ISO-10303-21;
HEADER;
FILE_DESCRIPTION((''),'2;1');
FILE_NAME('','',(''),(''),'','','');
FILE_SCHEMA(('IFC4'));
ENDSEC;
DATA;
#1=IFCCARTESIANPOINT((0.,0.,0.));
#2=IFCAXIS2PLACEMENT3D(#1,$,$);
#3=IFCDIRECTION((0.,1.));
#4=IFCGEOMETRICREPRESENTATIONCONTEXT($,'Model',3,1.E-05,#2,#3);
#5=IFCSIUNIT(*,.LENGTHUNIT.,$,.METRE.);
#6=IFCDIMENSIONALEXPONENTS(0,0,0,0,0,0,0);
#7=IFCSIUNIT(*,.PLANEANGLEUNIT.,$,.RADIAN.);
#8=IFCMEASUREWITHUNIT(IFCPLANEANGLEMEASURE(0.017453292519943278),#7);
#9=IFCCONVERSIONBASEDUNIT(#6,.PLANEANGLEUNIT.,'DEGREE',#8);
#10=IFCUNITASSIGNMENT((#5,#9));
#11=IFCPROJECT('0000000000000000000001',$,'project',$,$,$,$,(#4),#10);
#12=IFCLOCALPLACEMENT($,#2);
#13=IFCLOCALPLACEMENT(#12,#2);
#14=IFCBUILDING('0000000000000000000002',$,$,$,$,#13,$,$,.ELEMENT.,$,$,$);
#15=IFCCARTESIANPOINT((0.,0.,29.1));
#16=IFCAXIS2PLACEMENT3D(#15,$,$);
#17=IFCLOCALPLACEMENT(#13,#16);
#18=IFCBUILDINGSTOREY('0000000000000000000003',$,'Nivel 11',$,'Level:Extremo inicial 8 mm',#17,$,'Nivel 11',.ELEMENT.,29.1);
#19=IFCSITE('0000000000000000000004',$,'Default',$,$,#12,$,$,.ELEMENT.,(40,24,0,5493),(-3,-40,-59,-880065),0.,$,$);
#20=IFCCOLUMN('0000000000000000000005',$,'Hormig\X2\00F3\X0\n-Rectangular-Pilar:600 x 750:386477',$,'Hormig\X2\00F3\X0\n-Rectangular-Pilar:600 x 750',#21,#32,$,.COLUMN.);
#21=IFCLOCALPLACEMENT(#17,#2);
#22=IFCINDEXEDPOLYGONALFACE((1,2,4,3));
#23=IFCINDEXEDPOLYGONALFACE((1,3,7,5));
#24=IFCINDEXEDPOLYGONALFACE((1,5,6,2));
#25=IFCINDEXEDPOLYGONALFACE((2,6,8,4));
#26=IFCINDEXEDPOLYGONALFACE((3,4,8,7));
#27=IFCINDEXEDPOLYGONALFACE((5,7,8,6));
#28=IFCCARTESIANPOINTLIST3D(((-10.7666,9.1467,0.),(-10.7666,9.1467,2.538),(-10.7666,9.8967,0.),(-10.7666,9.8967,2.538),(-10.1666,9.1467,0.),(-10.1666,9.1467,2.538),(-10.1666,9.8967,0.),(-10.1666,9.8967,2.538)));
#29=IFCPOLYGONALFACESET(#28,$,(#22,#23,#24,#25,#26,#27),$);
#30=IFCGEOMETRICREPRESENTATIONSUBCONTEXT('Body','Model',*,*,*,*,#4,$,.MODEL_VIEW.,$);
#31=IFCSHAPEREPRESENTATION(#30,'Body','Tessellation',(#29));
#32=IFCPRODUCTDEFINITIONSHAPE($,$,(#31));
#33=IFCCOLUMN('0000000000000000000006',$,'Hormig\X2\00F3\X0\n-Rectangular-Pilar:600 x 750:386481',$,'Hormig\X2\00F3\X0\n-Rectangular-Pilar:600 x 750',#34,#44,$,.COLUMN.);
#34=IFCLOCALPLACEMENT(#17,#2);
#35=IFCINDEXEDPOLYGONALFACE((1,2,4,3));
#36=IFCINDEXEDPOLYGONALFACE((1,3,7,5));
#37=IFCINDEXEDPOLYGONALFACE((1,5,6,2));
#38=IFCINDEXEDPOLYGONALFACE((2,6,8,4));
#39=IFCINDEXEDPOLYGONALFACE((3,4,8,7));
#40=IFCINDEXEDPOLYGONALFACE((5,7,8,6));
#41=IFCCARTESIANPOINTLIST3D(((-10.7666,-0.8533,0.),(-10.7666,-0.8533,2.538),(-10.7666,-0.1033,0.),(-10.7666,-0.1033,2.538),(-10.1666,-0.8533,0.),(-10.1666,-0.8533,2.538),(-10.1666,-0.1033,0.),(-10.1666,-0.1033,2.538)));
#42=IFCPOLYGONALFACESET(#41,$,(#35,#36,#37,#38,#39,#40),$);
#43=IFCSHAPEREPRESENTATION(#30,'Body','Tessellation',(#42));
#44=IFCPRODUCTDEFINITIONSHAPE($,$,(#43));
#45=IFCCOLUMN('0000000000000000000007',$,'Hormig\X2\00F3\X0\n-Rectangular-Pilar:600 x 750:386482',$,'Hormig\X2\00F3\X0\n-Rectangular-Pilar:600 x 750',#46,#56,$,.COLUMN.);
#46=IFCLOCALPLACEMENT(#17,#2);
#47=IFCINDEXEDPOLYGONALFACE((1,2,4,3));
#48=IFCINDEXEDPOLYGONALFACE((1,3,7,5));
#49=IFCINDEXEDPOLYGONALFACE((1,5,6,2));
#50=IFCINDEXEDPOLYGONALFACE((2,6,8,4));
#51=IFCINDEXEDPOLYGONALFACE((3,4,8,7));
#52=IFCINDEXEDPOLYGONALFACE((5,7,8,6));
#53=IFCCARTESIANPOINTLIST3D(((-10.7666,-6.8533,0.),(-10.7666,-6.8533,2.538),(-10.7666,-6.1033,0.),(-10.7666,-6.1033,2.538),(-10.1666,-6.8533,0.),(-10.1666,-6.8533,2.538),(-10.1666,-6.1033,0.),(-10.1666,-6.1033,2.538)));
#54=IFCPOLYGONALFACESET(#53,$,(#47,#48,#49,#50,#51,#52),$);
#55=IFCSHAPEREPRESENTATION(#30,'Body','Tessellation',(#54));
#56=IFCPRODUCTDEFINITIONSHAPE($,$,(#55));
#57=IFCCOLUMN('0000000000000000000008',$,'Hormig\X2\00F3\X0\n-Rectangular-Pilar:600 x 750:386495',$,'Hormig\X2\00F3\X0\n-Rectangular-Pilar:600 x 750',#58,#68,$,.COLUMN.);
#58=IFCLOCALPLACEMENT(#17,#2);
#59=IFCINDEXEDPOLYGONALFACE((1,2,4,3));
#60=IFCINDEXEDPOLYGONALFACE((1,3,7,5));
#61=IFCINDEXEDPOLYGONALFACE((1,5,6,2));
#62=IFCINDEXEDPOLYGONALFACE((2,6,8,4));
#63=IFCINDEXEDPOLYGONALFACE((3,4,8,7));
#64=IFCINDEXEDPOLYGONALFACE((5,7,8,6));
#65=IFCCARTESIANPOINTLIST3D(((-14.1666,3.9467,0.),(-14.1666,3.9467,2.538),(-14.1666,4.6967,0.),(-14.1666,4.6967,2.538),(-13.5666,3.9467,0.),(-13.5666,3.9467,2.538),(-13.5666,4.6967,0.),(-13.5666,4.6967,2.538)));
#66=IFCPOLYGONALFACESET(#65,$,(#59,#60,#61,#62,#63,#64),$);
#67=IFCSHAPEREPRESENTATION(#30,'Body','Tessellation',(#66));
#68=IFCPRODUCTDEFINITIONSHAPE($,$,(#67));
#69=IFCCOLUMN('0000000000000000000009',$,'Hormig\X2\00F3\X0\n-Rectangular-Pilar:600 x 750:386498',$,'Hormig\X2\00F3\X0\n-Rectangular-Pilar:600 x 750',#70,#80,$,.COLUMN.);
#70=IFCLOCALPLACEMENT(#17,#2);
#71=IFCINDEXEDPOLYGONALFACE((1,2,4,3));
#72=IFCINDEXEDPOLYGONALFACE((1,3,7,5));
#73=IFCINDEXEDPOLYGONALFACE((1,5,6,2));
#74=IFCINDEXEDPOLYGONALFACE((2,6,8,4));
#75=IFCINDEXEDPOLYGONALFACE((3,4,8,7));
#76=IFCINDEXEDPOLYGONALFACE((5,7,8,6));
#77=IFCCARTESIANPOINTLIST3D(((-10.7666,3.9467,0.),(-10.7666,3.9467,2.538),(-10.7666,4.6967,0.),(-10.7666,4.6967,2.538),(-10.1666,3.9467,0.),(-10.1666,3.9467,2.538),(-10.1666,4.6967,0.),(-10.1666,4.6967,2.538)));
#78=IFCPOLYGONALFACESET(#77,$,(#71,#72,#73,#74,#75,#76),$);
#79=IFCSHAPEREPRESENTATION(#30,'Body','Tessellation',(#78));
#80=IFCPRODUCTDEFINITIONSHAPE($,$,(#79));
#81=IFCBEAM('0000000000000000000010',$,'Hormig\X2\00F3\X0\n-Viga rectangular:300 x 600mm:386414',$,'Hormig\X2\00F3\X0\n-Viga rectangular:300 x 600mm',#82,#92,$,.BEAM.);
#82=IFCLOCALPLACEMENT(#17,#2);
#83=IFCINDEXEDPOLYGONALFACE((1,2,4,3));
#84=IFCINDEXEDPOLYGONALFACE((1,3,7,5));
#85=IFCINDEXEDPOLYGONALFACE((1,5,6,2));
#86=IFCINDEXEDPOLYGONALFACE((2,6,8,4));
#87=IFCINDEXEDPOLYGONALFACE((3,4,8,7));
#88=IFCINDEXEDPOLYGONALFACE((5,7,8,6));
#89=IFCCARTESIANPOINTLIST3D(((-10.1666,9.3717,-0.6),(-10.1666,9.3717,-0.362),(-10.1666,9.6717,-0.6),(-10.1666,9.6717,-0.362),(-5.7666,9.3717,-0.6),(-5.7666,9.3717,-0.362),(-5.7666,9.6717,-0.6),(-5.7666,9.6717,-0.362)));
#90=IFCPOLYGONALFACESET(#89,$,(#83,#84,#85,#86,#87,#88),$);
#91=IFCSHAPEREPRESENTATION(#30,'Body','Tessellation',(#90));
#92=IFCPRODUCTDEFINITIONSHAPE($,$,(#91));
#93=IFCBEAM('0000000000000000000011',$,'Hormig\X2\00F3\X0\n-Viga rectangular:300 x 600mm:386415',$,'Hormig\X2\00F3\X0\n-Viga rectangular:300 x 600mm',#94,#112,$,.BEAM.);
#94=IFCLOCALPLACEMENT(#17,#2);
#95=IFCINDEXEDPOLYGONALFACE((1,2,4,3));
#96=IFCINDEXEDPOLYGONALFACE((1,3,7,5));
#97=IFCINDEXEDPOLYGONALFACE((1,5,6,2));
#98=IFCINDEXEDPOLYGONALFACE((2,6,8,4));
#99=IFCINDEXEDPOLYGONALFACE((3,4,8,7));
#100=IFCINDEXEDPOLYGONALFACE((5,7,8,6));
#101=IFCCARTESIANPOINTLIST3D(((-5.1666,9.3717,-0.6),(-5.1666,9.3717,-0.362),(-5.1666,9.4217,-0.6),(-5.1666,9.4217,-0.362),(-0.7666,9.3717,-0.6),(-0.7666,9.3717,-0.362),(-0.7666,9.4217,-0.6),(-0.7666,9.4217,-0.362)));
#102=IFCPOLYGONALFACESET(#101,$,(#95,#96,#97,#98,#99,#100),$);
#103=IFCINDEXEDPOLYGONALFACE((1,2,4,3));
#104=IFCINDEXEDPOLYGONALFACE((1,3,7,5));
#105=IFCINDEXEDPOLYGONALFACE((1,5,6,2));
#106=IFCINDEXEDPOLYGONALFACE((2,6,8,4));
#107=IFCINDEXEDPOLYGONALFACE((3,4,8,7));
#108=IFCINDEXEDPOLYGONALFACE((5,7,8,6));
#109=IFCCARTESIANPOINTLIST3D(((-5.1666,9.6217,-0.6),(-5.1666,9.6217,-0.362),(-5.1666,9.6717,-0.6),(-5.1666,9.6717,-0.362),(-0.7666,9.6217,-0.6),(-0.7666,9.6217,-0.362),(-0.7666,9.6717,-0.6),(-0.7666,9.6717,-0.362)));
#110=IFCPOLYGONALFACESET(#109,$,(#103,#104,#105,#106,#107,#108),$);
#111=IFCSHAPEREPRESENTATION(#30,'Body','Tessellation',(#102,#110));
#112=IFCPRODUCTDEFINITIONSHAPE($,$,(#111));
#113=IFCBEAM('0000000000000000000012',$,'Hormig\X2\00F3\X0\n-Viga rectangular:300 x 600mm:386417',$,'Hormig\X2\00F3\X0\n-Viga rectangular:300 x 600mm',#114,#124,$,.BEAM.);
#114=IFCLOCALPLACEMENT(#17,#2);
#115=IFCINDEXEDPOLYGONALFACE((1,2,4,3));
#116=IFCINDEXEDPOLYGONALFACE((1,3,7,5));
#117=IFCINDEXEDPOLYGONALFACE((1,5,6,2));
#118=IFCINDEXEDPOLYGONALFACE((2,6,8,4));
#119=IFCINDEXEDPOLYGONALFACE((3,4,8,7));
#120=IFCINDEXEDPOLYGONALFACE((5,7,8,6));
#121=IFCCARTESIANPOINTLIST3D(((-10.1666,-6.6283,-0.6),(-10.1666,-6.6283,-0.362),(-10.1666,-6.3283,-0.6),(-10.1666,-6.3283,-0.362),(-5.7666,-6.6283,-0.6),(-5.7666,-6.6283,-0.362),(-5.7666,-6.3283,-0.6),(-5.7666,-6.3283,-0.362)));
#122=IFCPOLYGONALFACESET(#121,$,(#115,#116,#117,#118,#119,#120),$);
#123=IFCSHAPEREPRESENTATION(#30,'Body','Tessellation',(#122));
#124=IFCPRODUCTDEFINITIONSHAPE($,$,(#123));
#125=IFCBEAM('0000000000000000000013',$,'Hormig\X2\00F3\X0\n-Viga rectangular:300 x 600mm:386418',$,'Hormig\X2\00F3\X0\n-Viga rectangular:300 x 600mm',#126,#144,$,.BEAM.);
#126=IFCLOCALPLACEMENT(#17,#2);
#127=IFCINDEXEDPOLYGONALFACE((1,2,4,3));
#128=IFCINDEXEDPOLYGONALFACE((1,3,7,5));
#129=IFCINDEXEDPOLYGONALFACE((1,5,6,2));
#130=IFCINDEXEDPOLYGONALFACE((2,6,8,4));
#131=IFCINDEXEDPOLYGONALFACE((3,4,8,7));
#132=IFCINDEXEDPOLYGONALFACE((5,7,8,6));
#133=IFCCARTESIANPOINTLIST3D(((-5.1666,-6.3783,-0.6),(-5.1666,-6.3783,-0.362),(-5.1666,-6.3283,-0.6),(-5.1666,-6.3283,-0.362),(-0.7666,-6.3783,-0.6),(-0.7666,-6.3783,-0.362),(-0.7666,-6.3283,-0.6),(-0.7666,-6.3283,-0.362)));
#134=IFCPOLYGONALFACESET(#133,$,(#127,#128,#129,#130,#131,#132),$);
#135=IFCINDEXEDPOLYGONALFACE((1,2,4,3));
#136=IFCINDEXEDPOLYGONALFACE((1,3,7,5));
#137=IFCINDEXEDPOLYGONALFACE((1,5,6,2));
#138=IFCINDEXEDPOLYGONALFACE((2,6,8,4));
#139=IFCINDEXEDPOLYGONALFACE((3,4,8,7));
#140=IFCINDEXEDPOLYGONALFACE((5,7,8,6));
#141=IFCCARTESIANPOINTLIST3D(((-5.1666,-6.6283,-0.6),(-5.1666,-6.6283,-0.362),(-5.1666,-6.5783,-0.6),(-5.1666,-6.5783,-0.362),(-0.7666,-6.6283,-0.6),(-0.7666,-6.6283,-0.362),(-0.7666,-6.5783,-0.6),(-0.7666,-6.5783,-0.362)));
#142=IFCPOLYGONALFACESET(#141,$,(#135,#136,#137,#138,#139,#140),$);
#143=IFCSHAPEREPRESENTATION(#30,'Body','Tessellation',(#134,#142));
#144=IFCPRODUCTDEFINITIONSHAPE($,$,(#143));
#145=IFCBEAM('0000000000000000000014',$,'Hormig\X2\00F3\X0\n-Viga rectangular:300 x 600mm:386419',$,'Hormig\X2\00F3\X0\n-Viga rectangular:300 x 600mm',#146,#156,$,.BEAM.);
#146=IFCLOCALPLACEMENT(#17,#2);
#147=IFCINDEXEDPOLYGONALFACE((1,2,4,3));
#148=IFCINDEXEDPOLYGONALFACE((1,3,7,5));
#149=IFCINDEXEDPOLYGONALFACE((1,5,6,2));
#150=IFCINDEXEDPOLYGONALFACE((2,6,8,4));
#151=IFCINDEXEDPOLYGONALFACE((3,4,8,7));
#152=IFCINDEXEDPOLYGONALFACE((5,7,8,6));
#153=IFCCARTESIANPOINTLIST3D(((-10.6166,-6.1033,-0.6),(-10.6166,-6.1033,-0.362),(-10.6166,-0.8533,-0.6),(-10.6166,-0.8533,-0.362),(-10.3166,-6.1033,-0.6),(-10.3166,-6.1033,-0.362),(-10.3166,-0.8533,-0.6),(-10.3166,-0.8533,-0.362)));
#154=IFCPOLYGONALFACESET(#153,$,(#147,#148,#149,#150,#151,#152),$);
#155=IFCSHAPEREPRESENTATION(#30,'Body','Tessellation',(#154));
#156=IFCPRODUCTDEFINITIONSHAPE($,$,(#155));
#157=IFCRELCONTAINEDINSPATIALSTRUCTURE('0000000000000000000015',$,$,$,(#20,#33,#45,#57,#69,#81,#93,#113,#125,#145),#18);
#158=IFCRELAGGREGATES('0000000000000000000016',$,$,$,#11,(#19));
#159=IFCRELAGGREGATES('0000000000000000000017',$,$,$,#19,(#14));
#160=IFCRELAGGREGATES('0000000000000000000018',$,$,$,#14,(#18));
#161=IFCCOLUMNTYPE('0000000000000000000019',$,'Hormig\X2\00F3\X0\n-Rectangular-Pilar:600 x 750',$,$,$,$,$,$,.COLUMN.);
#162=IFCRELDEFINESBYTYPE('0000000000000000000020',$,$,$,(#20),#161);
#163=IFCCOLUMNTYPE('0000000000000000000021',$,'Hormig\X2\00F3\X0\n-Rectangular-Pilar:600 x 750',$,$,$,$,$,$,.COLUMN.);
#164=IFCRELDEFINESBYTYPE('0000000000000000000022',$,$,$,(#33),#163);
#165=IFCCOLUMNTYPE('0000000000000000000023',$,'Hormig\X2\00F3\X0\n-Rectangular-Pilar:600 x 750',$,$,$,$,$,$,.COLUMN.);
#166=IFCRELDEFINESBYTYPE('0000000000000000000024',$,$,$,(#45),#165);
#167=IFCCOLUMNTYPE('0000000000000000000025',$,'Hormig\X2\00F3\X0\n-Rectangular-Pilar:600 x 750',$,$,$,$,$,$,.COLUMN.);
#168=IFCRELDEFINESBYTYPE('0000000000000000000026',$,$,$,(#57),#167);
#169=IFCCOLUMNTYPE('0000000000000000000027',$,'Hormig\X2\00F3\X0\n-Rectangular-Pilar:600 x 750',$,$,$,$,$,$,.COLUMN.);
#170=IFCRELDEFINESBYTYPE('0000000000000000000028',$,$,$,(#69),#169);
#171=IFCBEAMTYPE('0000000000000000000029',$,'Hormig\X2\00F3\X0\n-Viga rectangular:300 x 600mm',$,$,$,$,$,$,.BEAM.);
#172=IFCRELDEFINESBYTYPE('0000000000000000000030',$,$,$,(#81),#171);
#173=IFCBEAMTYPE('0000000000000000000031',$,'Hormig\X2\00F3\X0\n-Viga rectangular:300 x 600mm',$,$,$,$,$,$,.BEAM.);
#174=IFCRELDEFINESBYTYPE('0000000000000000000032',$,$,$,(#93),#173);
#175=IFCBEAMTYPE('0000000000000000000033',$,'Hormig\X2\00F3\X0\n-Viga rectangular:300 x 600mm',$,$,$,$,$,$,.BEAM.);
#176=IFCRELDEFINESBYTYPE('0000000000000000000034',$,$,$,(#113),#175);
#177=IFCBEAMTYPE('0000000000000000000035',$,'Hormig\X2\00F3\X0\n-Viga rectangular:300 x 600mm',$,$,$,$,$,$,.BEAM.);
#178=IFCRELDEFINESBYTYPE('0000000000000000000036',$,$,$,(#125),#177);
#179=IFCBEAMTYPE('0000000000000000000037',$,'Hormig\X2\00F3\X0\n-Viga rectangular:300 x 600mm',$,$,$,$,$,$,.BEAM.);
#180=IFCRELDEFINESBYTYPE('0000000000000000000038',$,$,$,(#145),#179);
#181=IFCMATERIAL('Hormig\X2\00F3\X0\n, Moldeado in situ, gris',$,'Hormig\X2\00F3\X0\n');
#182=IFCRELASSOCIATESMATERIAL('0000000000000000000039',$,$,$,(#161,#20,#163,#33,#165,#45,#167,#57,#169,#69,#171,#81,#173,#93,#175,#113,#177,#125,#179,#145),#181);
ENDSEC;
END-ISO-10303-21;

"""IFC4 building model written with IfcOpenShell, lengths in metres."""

from ifc_helpers import new_model, entity, si_unit, converted_unit, direction, frame, origin, place, context, subcontext, project, spatial, indexed_curve, outline, extrude, source, transform, mapped, material, type_object, type_shapes, element, save


model = new_model("IFC4")

# Units and contexts
model_context = context("Model", 3, precision=1e-05, world=origin(), true_north=direction((0.0, 1.0)))
body_context = subcontext(model_context, "Body", "Model", "MODEL_VIEW")
ifc_project = project(units=[si_unit("LENGTHUNIT", "METRE"), converted_unit("PLANEANGLEUNIT", "DEGREE", entity("IfcPlaneAngleMeasure", 0.017453292519943278), si_unit("PLANEANGLEUNIT", "RADIAN"), dimensions=[0, 0, 0, 0, 0, 0, 0])], contexts=[model_context])

# Site, building, storey
site_placement = place(None, origin())
site = spatial("IfcSite", under=ifc_project, at=site_placement, Name="Default", CompositionType="ELEMENT", RefLatitude=(40, 24, 0, 5493), RefLongitude=(-3, -40, -59, -880065), RefElevation=0.0)
building_placement = place(site_placement, origin())
building = spatial("IfcBuilding", under=site, at=building_placement, CompositionType="ELEMENT")
storey_placement = place(building_placement, frame((0.0, 0.0, 29.1)))
storey = spatial("IfcBuildingStorey", under=building, at=storey_placement, Name="Nivel 11", ObjectType="Level:Extremo inicial 8 mm", LongName="Nivel 11", CompositionType="ELEMENT", Elevation=29.1)

# Columns
ifc_material_1 = material(Name="Hormigón, Moldeado in situ, gris", Category="Hormigón")
column_type_1 = type_object("IfcColumnType", Name="Hormigón-Rectangular-Pilar:600 x 750", PredefinedType="COLUMN", material=ifc_material_1)
shared_shape_1 = source(origin(), body_context, "Body", "SweptSolid", [
    extrude(outline(indexed_curve([(-0.3, -0.375), (0.3, -0.375), (0.3, 0.375), (-0.3, 0.375), (-0.3, -0.375)], self_intersect=False)), frame((-10.4666, 9.5217, 29.1), z_axis=(0.0, 0.0, 1.0), x_axis=(-1.0, 0.0, 0.0)), (0.0, 0.0, 1.0), 2.538),
])
type_shapes(column_type_1, [shared_shape_1])
column_1_placement = place(storey_placement, frame((0.0, 0.0, -29.1)))
element("IfcColumn", 1, at=column_1_placement, inside=storey, type_object=column_type_1, material=ifc_material_1, Name="Hormigón-Rectangular-Pilar:600 x 750:386477", ObjectType="Hormigón-Rectangular-Pilar:600 x 750", PredefinedType="COLUMN", context=body_context, shape_type="MappedRepresentation", body=[
    mapped(shared_shape_1, transform((0.0, 0.0, 0.0), scale=1.0)),
])
column_type_2 = type_object("IfcColumnType", Name="Hormigón-Rectangular-Pilar:600 x 750", PredefinedType="COLUMN", material=ifc_material_1)
shared_shape_2 = source(origin(), body_context, "Body", "SweptSolid", [
    extrude(outline(indexed_curve([(-0.3, -0.375), (0.3, -0.375), (0.3, 0.375), (-0.3, 0.375), (-0.3, -0.375)], self_intersect=False)), frame((-10.4666, -0.4783, 29.1), z_axis=(0.0, 0.0, 1.0), x_axis=(-1.0, 0.0, 0.0)), (0.0, 0.0, 1.0), 2.538),
])
type_shapes(column_type_2, [shared_shape_2])
column_2_placement = place(storey_placement, frame((0.0, 0.0, -29.1)))
element("IfcColumn", 2, at=column_2_placement, inside=storey, type_object=column_type_2, material=ifc_material_1, Name="Hormigón-Rectangular-Pilar:600 x 750:386481", ObjectType="Hormigón-Rectangular-Pilar:600 x 750", PredefinedType="COLUMN", context=body_context, shape_type="MappedRepresentation", body=[
    mapped(shared_shape_2, transform((0.0, 0.0, 0.0), scale=1.0)),
])
column_type_3 = type_object("IfcColumnType", Name="Hormigón-Rectangular-Pilar:600 x 750", PredefinedType="COLUMN", material=ifc_material_1)
shared_shape_3 = source(origin(), body_context, "Body", "SweptSolid", [
    extrude(outline(indexed_curve([(-0.3, -0.375), (0.3, -0.375), (0.3, 0.375), (-0.3, 0.375), (-0.3, -0.375)], self_intersect=False)), frame((-10.4666, -6.4783, 29.1), z_axis=(0.0, 0.0, 1.0), x_axis=(-1.0, 0.0, 0.0)), (0.0, 0.0, 1.0), 2.538),
])
type_shapes(column_type_3, [shared_shape_3])
column_3_placement = place(storey_placement, frame((0.0, 0.0, -29.1)))
element("IfcColumn", 3, at=column_3_placement, inside=storey, type_object=column_type_3, material=ifc_material_1, Name="Hormigón-Rectangular-Pilar:600 x 750:386482", ObjectType="Hormigón-Rectangular-Pilar:600 x 750", PredefinedType="COLUMN", context=body_context, shape_type="MappedRepresentation", body=[
    mapped(shared_shape_3, transform((0.0, 0.0, 0.0), scale=1.0)),
])
column_type_4 = type_object("IfcColumnType", Name="Hormigón-Rectangular-Pilar:600 x 750", PredefinedType="COLUMN", material=ifc_material_1)
shared_shape_4 = source(origin(), body_context, "Body", "SweptSolid", [
    extrude(outline(indexed_curve([(-0.3, -0.375), (0.3, -0.375), (0.3, 0.375), (-0.3, 0.375), (-0.3, -0.375)], self_intersect=False)), frame((-13.8666, 4.3217, 29.1), z_axis=(0.0, 0.0, 1.0), x_axis=(-1.0, 0.0, 0.0)), (0.0, 0.0, 1.0), 2.538),
])
type_shapes(column_type_4, [shared_shape_4])
column_4_placement = place(storey_placement, frame((0.0, 0.0, -29.1)))
element("IfcColumn", 4, at=column_4_placement, inside=storey, type_object=column_type_4, material=ifc_material_1, Name="Hormigón-Rectangular-Pilar:600 x 750:386495", ObjectType="Hormigón-Rectangular-Pilar:600 x 750", PredefinedType="COLUMN", context=body_context, shape_type="MappedRepresentation", body=[
    mapped(shared_shape_4, transform((0.0, 0.0, 0.0), scale=1.0)),
])
column_type_5 = type_object("IfcColumnType", Name="Hormigón-Rectangular-Pilar:600 x 750", PredefinedType="COLUMN", material=ifc_material_1)
shared_shape_5 = source(origin(), body_context, "Body", "SweptSolid", [
    extrude(outline(indexed_curve([(-0.3, -0.375), (0.3, -0.375), (0.3, 0.375), (-0.3, 0.375), (-0.3, -0.375)], self_intersect=False)), frame((-10.4666, 4.3217, 29.1), z_axis=(0.0, 0.0, 1.0), x_axis=(-1.0, 0.0, 0.0)), (0.0, 0.0, 1.0), 2.538),
])
type_shapes(column_type_5, [shared_shape_5])
column_5_placement = place(storey_placement, frame((0.0, 0.0, -29.1)))
element("IfcColumn", 5, at=column_5_placement, inside=storey, type_object=column_type_5, material=ifc_material_1, Name="Hormigón-Rectangular-Pilar:600 x 750:386498", ObjectType="Hormigón-Rectangular-Pilar:600 x 750", PredefinedType="COLUMN", context=body_context, shape_type="MappedRepresentation", body=[
    mapped(shared_shape_5, transform((0.0, 0.0, 0.0), scale=1.0)),
])

# Beams
beam_type_1 = type_object("IfcBeamType", Name="Hormigón-Viga rectangular:300 x 600mm", PredefinedType="BEAM", material=ifc_material_1)
shared_shape_6 = source(origin(), body_context, "Body", "SweptSolid", [
    extrude(outline(indexed_curve([(-0.119, -0.15), (0.119, -0.15), (0.119, 0.15), (-0.119, 0.15), (-0.119, -0.15)], self_intersect=False)), frame((-5.7666, 9.5217, 28.619), z_axis=(-1.0, 0.0, 0.0), x_axis=(0.0, 0.0, -1.0)), (0.0, 0.0, 1.0), 4.4),
])
type_shapes(beam_type_1, [shared_shape_6])
beam_1_placement = place(storey_placement, frame((0.0, 0.0, -29.1)))
element("IfcBeam", 6, at=beam_1_placement, inside=storey, type_object=beam_type_1, material=ifc_material_1, Name="Hormigón-Viga rectangular:300 x 600mm:386414", ObjectType="Hormigón-Viga rectangular:300 x 600mm", PredefinedType="BEAM", context=body_context, shape_type="MappedRepresentation", body=[
    mapped(shared_shape_6, transform((0.0, 0.0, 0.0), scale=1.0)),
])
beam_type_2 = type_object("IfcBeamType", Name="Hormigón-Viga rectangular:300 x 600mm", PredefinedType="BEAM", material=ifc_material_1)
shared_shape_7 = source(origin(), body_context, "Body", "SweptSolid", [
    extrude(outline(indexed_curve([(-0.119, -0.025), (0.119, -0.025), (0.119, 0.025), (-0.119, 0.025), (-0.119, -0.025)], self_intersect=False)), frame((-5.1666, 9.3967, 28.619), z_axis=(1.0, 0.0, 0.0), x_axis=(0.0, 0.0, -1.0)), (0.0, 0.0, 1.0), 4.4),
    extrude(outline(indexed_curve([(-0.119, -0.025), (0.119, -0.025), (0.119, 0.025), (-0.119, 0.025), (-0.119, -0.025)], self_intersect=False)), frame((-5.1666, 9.6467, 28.619), z_axis=(1.0, 0.0, 0.0), x_axis=(0.0, 0.0, -1.0)), (0.0, 0.0, 1.0), 4.4),
])
type_shapes(beam_type_2, [shared_shape_7])
beam_2_placement = place(storey_placement, frame((0.0, 0.0, -29.1)))
element("IfcBeam", 7, at=beam_2_placement, inside=storey, type_object=beam_type_2, material=ifc_material_1, Name="Hormigón-Viga rectangular:300 x 600mm:386415", ObjectType="Hormigón-Viga rectangular:300 x 600mm", PredefinedType="BEAM", context=body_context, shape_type="MappedRepresentation", body=[
    mapped(shared_shape_7, transform((0.0, 0.0, 0.0), scale=1.0)),
])
beam_type_3 = type_object("IfcBeamType", Name="Hormigón-Viga rectangular:300 x 600mm", PredefinedType="BEAM", material=ifc_material_1)
shared_shape_8 = source(origin(), body_context, "Body", "SweptSolid", [
    extrude(outline(indexed_curve([(-0.119, -0.15), (0.119, -0.15), (0.119, 0.15), (-0.119, 0.15), (-0.119, -0.15)], self_intersect=False)), frame((-10.1666, -6.4783, 28.619), z_axis=(1.0, 0.0, 0.0), x_axis=(0.0, 0.0, -1.0)), (0.0, 0.0, 1.0), 4.4),
])
type_shapes(beam_type_3, [shared_shape_8])
beam_3_placement = place(storey_placement, frame((0.0, 0.0, -29.1)))
element("IfcBeam", 8, at=beam_3_placement, inside=storey, type_object=beam_type_3, material=ifc_material_1, Name="Hormigón-Viga rectangular:300 x 600mm:386417", ObjectType="Hormigón-Viga rectangular:300 x 600mm", PredefinedType="BEAM", context=body_context, shape_type="MappedRepresentation", body=[
    mapped(shared_shape_8, transform((0.0, 0.0, 0.0), scale=1.0)),
])
beam_type_4 = type_object("IfcBeamType", Name="Hormigón-Viga rectangular:300 x 600mm", PredefinedType="BEAM", material=ifc_material_1)
shared_shape_9 = source(origin(), body_context, "Body", "SweptSolid", [
    extrude(outline(indexed_curve([(-0.119, -0.025), (0.119, -0.025), (0.119, 0.025), (-0.119, 0.025), (-0.119, -0.025)], self_intersect=False)), frame((-0.7666, -6.3533, 28.619), z_axis=(-1.0, 0.0, 0.0), x_axis=(0.0, 0.0, -1.0)), (0.0, 0.0, 1.0), 4.4),
    extrude(outline(indexed_curve([(-0.119, -0.025), (0.119, -0.025), (0.119, 0.025), (-0.119, 0.025), (-0.119, -0.025)], self_intersect=False)), frame((-0.7666, -6.6033, 28.619), z_axis=(-1.0, 0.0, 0.0), x_axis=(0.0, 0.0, -1.0)), (0.0, 0.0, 1.0), 4.4),
])
type_shapes(beam_type_4, [shared_shape_9])
beam_4_placement = place(storey_placement, frame((0.0, 0.0, -29.1)))
element("IfcBeam", 9, at=beam_4_placement, inside=storey, type_object=beam_type_4, material=ifc_material_1, Name="Hormigón-Viga rectangular:300 x 600mm:386418", ObjectType="Hormigón-Viga rectangular:300 x 600mm", PredefinedType="BEAM", context=body_context, shape_type="MappedRepresentation", body=[
    mapped(shared_shape_9, transform((0.0, 0.0, 0.0), scale=1.0)),
])
beam_type_5 = type_object("IfcBeamType", Name="Hormigón-Viga rectangular:300 x 600mm", PredefinedType="BEAM", material=ifc_material_1)
shared_shape_10 = source(origin(), body_context, "Body", "SweptSolid", [
    extrude(outline(indexed_curve([(-0.15, -0.119), (0.15, -0.119), (0.15, 0.119), (-0.15, 0.119), (-0.15, -0.119)], self_intersect=False)), frame((-10.4666, -6.1033, 28.619), z_axis=(0.0, 1.0, 0.0), x_axis=(-1.0, 0.0, 0.0)), (0.0, 0.0, 1.0), 5.25),
])
type_shapes(beam_type_5, [shared_shape_10])
beam_5_placement = place(storey_placement, frame((0.0, 0.0, -29.1)))
element("IfcBeam", 10, at=beam_5_placement, inside=storey, type_object=beam_type_5, material=ifc_material_1, Name="Hormigón-Viga rectangular:300 x 600mm:386419", ObjectType="Hormigón-Viga rectangular:300 x 600mm", PredefinedType="BEAM", context=body_context, shape_type="MappedRepresentation", body=[
    mapped(shared_shape_10, transform((0.0, 0.0, 0.0), scale=1.0)),
])

save(model, "model.ifc")
